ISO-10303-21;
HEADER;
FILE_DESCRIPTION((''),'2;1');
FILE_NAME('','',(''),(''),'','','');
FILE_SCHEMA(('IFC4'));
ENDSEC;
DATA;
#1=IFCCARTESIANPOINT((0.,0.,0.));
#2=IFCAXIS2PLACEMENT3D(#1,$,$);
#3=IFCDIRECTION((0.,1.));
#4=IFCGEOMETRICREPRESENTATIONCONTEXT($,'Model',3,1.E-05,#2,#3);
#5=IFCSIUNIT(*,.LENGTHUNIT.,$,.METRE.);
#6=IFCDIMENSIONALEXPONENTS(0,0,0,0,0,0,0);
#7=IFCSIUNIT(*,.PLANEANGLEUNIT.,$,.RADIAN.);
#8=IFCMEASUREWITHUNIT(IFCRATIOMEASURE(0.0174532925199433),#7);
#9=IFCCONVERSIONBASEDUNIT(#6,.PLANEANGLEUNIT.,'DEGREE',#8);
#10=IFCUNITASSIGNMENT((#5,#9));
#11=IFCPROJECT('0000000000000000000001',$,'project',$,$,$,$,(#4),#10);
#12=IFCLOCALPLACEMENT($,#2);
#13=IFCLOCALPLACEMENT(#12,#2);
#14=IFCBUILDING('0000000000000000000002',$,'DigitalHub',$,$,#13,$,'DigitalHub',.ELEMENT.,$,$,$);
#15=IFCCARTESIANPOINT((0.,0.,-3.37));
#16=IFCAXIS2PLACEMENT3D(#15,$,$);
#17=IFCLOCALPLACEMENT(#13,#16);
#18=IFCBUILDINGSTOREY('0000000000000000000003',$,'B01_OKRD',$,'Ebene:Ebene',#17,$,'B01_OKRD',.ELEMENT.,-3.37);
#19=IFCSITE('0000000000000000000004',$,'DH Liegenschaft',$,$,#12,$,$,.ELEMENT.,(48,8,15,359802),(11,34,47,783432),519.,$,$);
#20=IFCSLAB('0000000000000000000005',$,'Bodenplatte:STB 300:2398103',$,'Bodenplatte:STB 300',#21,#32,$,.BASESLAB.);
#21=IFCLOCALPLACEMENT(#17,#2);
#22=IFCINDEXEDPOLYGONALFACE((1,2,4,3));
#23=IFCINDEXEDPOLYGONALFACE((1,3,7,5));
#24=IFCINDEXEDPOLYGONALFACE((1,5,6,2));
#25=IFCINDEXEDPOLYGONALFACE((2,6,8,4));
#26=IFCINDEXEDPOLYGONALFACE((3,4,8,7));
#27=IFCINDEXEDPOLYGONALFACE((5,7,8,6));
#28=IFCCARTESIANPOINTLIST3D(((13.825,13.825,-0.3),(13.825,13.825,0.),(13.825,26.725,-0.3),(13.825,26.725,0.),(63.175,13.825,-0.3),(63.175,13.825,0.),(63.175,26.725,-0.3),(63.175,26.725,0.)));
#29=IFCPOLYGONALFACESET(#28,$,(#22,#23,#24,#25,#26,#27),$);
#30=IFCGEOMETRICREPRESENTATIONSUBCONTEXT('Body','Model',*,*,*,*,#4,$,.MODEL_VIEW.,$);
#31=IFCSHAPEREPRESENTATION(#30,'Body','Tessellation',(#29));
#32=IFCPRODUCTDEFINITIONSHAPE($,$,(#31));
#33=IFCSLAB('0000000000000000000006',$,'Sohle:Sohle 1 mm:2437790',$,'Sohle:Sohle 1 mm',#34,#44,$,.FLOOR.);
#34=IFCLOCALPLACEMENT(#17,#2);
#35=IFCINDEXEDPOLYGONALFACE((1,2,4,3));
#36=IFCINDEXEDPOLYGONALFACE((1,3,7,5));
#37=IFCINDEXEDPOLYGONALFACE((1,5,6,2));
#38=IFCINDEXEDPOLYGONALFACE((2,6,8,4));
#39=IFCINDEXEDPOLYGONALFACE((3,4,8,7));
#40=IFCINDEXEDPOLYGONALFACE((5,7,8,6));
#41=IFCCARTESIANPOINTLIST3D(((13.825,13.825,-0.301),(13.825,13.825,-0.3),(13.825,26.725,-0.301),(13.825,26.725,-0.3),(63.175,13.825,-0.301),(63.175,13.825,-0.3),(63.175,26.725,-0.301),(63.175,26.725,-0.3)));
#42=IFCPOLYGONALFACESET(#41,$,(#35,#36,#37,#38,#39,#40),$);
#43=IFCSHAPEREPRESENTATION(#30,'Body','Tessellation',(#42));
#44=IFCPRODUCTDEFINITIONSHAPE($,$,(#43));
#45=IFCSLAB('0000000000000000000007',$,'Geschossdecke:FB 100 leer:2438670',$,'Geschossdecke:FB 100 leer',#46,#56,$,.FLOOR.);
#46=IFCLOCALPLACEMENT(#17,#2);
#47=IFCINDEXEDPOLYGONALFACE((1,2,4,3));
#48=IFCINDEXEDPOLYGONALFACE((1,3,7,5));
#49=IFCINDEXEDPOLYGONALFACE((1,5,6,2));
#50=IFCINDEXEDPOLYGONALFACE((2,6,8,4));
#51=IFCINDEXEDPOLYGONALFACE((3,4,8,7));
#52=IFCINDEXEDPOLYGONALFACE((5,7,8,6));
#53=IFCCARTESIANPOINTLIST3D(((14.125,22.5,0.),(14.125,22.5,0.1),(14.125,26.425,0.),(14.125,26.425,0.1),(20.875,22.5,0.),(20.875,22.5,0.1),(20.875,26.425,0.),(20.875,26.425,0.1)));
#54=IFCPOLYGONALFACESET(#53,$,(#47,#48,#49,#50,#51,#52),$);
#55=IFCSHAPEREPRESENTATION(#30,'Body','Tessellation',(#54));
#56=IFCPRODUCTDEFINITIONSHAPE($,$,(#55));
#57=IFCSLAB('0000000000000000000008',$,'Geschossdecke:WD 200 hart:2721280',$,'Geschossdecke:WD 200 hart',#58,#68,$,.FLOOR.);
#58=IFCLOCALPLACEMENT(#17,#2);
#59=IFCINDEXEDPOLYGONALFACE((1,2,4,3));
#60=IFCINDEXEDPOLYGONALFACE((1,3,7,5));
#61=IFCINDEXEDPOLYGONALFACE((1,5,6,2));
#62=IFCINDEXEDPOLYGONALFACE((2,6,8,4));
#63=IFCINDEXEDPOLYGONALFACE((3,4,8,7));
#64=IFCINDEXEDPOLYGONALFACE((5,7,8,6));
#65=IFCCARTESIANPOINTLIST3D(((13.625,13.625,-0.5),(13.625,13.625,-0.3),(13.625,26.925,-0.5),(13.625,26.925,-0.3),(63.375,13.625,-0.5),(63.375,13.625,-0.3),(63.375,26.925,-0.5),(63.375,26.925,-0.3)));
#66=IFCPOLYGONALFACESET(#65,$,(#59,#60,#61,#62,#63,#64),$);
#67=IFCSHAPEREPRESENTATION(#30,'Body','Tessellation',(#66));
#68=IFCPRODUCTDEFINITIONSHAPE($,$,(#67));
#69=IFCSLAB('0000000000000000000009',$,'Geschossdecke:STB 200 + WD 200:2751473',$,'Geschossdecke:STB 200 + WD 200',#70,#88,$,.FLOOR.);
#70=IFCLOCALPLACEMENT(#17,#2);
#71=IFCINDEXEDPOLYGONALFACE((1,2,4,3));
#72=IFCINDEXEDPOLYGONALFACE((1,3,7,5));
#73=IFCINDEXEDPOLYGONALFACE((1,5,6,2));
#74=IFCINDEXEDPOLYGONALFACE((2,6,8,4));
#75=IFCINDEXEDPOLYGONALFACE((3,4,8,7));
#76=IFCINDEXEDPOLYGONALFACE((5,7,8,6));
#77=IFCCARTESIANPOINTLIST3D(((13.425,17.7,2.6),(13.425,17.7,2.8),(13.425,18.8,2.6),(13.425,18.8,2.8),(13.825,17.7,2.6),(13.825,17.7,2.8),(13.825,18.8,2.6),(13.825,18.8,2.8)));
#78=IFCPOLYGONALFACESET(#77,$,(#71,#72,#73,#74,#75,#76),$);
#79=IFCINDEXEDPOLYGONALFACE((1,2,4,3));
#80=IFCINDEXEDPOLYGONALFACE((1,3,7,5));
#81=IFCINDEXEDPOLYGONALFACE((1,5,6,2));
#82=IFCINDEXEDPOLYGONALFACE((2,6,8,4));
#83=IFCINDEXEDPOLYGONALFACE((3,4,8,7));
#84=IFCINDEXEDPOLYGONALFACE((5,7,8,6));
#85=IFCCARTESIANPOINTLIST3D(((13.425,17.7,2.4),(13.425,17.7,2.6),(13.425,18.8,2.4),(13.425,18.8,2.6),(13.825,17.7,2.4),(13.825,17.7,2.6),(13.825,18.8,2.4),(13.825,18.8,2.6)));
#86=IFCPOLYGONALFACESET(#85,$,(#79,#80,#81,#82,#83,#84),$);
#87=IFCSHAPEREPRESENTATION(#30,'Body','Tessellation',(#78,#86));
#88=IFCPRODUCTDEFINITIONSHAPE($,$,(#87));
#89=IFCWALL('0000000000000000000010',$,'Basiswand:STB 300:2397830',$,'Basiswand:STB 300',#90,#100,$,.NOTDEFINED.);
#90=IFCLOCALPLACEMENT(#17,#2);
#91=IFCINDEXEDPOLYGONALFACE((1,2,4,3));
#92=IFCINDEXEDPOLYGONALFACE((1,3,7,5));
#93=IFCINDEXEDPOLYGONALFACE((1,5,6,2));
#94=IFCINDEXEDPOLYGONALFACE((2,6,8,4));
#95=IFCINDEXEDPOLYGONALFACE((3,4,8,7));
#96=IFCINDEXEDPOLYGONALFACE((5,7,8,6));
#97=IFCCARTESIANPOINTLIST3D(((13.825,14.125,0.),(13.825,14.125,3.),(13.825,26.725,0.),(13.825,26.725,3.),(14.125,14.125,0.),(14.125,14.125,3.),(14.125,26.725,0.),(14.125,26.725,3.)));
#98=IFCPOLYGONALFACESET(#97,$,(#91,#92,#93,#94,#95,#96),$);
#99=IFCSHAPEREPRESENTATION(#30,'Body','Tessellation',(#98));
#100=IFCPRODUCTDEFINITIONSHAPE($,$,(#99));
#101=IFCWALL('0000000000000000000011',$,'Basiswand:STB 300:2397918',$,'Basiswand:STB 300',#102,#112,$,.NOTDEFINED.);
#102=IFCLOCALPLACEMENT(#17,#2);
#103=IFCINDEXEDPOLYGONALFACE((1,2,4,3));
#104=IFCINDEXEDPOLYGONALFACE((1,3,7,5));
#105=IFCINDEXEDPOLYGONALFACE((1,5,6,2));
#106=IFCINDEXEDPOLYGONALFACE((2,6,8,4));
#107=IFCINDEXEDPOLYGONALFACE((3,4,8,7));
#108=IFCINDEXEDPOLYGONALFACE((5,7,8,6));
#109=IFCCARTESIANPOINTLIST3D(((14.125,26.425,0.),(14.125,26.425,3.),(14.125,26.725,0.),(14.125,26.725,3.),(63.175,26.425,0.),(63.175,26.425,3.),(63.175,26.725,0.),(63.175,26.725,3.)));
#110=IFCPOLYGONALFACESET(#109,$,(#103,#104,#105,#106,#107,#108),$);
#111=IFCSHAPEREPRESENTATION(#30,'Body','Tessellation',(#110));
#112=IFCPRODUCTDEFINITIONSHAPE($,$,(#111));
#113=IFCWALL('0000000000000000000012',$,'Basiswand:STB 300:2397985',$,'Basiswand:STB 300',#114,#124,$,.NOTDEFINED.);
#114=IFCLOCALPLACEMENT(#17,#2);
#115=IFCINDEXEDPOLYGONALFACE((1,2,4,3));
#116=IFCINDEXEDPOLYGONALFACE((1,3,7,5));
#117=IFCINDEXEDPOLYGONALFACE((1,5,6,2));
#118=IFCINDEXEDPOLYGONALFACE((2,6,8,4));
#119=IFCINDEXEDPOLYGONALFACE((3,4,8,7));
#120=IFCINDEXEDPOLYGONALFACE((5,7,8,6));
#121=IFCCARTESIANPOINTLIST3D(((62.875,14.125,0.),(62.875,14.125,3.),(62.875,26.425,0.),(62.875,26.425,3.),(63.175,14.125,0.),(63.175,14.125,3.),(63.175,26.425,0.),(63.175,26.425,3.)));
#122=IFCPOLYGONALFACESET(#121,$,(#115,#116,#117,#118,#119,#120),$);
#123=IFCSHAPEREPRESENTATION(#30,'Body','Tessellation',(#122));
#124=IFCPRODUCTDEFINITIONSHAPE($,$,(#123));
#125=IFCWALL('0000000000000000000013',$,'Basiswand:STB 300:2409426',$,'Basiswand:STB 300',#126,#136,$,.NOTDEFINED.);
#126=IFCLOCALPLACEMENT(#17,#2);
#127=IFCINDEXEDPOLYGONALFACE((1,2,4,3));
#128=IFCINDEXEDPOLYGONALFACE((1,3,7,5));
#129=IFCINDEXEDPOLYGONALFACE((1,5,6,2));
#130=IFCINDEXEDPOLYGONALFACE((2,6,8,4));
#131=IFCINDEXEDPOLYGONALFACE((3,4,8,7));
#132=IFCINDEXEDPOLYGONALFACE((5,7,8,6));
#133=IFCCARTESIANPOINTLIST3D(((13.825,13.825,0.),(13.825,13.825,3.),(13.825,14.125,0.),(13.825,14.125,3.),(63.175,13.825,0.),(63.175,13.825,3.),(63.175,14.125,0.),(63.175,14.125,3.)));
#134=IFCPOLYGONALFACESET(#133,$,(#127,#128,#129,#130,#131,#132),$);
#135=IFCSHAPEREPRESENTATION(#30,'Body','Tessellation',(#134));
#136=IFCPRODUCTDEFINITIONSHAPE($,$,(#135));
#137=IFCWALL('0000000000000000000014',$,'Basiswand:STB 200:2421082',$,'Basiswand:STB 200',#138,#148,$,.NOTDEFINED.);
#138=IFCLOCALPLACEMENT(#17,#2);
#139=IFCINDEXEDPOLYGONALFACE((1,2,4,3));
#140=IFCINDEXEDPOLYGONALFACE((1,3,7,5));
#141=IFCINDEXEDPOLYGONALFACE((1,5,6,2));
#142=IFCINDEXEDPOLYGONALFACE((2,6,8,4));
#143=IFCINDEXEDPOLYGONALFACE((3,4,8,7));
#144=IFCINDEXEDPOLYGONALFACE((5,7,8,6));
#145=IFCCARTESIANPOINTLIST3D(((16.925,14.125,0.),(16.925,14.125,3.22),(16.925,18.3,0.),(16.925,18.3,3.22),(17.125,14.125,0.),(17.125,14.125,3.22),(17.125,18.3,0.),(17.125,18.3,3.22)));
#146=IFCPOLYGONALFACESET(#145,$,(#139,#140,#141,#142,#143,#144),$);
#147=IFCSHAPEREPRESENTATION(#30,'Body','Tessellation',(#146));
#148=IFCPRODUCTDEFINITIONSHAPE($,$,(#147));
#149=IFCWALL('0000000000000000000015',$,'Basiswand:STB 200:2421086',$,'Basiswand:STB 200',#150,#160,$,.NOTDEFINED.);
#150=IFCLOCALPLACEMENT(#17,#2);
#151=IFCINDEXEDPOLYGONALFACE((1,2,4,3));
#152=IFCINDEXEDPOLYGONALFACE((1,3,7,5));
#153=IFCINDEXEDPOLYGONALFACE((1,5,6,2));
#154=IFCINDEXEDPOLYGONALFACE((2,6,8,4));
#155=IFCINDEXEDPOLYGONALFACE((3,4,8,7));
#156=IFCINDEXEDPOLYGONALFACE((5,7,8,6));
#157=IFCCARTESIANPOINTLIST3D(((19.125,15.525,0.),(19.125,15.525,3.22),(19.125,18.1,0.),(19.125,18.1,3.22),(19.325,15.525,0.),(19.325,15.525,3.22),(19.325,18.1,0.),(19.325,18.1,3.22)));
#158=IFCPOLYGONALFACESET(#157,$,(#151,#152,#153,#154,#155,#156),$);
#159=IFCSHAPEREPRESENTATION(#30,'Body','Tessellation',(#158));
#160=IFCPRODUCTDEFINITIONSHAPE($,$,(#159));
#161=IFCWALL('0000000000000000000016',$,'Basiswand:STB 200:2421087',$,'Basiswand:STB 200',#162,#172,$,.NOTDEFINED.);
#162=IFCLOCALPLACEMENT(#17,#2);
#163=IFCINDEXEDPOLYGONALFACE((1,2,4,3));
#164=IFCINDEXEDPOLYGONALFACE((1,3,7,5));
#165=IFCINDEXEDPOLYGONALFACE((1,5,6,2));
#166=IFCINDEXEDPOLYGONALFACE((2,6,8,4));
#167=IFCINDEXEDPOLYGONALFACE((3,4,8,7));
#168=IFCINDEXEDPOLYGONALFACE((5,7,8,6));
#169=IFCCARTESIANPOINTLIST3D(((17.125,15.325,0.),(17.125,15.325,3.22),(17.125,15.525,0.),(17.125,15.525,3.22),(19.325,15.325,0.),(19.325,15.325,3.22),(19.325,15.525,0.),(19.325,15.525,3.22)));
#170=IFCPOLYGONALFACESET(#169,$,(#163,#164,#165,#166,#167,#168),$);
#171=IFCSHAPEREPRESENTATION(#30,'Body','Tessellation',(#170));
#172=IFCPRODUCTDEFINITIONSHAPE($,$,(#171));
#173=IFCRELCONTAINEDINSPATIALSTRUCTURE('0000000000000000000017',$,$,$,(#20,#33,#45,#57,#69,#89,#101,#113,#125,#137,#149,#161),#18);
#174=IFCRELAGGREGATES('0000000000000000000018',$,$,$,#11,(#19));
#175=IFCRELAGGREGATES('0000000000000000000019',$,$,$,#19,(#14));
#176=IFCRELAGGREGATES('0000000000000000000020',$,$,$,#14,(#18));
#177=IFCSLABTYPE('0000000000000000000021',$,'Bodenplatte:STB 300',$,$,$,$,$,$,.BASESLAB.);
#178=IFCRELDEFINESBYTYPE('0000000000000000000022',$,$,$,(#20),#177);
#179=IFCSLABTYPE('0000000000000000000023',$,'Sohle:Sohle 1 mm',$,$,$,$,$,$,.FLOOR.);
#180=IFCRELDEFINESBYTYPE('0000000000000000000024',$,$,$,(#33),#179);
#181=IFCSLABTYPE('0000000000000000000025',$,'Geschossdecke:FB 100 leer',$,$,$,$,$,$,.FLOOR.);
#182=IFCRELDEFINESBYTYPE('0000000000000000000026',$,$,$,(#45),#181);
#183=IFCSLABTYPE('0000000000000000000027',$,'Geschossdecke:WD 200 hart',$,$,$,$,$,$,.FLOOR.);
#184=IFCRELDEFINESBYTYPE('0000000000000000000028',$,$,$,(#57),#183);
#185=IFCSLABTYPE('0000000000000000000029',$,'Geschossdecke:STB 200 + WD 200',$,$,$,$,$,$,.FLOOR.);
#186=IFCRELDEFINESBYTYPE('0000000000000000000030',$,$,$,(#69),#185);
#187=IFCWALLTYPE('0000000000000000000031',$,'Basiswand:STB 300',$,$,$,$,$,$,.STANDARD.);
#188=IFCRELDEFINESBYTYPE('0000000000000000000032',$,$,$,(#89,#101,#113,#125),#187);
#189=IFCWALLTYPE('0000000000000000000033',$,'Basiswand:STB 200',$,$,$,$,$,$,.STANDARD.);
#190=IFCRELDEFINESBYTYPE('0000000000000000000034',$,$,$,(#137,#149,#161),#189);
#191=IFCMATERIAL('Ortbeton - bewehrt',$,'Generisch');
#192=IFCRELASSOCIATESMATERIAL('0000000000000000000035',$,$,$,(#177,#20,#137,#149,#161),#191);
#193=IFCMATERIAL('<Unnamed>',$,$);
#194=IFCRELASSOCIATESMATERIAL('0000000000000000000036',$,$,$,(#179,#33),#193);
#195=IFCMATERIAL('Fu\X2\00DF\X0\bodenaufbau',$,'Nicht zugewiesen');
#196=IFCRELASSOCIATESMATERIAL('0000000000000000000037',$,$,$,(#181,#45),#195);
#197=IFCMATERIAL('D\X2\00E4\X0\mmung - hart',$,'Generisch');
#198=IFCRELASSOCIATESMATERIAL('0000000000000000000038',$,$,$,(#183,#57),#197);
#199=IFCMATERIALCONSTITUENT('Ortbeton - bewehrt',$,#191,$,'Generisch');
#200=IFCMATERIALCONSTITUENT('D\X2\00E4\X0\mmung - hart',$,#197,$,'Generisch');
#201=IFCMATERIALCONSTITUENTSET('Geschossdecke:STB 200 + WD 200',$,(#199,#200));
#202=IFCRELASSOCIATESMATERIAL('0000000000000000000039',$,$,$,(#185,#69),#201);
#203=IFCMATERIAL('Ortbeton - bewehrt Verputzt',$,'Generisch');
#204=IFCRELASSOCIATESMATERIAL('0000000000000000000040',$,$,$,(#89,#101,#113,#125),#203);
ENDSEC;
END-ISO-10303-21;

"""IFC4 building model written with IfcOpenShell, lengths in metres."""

from ifc_helpers import new_model, entity, si_unit, converted_unit, direction, frame, origin, place, context, subcontext, project, spatial, indexed_curve, outline, extrude, material, constituent, constituent_set, type_object, element, save


model = new_model("IFC4")

# Units and contexts
model_context = context("Model", 3, precision=1e-05, world=origin(), true_north=direction((0.0, 1.0)))
body_context = subcontext(model_context, "Body", "Model", "MODEL_VIEW")
ifc_project = project(units=[si_unit("LENGTHUNIT", "METRE"), converted_unit("PLANEANGLEUNIT", "DEGREE", entity("IfcRatioMeasure", 0.0174532925199433), si_unit("PLANEANGLEUNIT", "RADIAN"), dimensions=[0, 0, 0, 0, 0, 0, 0])], contexts=[model_context])

# Site, building, storey
site_placement = place(None, frame((0.0, 0.0, 0.0)))
site = spatial("IfcSite", under=ifc_project, at=site_placement, Name="DH Liegenschaft", CompositionType="ELEMENT", RefLatitude=(48, 8, 15, 359802), RefLongitude=(11, 34, 47, 783432), RefElevation=519.0)
building_placement = place(site_placement, origin())
building = spatial("IfcBuilding", under=site, at=building_placement, Name="DigitalHub", LongName="DigitalHub", CompositionType="ELEMENT")
storey_placement = place(building_placement, frame((0.0, 0.0, -3.37)))
storey = spatial("IfcBuildingStorey", under=building, at=storey_placement, Name="B01_OKRD", ObjectType="Ebene:Ebene", LongName="B01_OKRD", CompositionType="ELEMENT", Elevation=-3.37)

# Slabs
ifc_material_1 = material(Name="Ortbeton - bewehrt", Category="Generisch")
slab_type_1 = type_object("IfcSlabType", Name="Bodenplatte:STB 300", PredefinedType="BASESLAB", material=ifc_material_1)
slab_1_placement = place(storey_placement, origin())
element("IfcSlab", 1, at=slab_1_placement, inside=storey, type_object=slab_type_1, material=ifc_material_1, Name="Bodenplatte:STB 300:2398103", ObjectType="Bodenplatte:STB 300", PredefinedType="BASESLAB", context=body_context, shape_type="SweptSolid", body=[
    extrude(outline(indexed_curve([(-6.45, -24.675), (6.45, -24.675), (6.45, 24.675), (-6.45, 24.675), (-6.45, -24.675)], self_intersect=False)), frame((38.5, 20.275, 0.0), z_axis=(0.0, 0.0, -1.0), x_axis=(0.0, 1.0, 0.0)), (0.0, 0.0, 1.0), 0.3),
])
ifc_material_2 = material(Name="<Unnamed>")
slab_type_2 = type_object("IfcSlabType", Name="Sohle:Sohle 1 mm", PredefinedType="FLOOR", material=ifc_material_2)
slab_2_placement = place(storey_placement, origin())
element("IfcSlab", 2, at=slab_2_placement, inside=storey, type_object=slab_type_2, material=ifc_material_2, Name="Sohle:Sohle 1 mm:2437790", ObjectType="Sohle:Sohle 1 mm", PredefinedType="FLOOR", context=body_context, shape_type="SweptSolid", body=[
    extrude(outline(indexed_curve([(-6.45, -24.675), (6.45, -24.675), (6.45, 24.675), (-6.45, 24.675), (-6.45, -24.675)], self_intersect=False)), frame((38.5, 20.275, -0.301), z_axis=(0.0, 0.0, 1.0), x_axis=(0.0, 1.0, 0.0)), (0.0, 0.0, 1.0), 0.001),
])
ifc_material_3 = material(Name="Fußbodenaufbau", Category="Nicht zugewiesen")
slab_type_3 = type_object("IfcSlabType", Name="Geschossdecke:FB 100 leer", PredefinedType="FLOOR", material=ifc_material_3)
slab_3_placement = place(storey_placement, origin())
element("IfcSlab", 3, at=slab_3_placement, inside=storey, type_object=slab_type_3, material=ifc_material_3, Name="Geschossdecke:FB 100 leer:2438670", ObjectType="Geschossdecke:FB 100 leer", PredefinedType="FLOOR", context=body_context, shape_type="SweptSolid", body=[
    extrude(outline(indexed_curve([(-1.9625, -3.375), (1.9625, -3.375), (1.9625, 3.375), (-1.9625, 3.375), (-1.9625, -3.375)], self_intersect=False)), frame((17.5, 24.4625, 0.1), z_axis=(0.0, 0.0, -1.0), x_axis=(0.0, 1.0, 0.0)), (0.0, 0.0, 1.0), 0.1),
])
ifc_material_4 = material(Name="Dämmung - hart", Category="Generisch")
slab_type_4 = type_object("IfcSlabType", Name="Geschossdecke:WD 200 hart", PredefinedType="FLOOR", material=ifc_material_4)
slab_4_placement = place(storey_placement, origin())
element("IfcSlab", 4, at=slab_4_placement, inside=storey, type_object=slab_type_4, material=ifc_material_4, Name="Geschossdecke:WD 200 hart:2721280", ObjectType="Geschossdecke:WD 200 hart", PredefinedType="FLOOR", context=body_context, shape_type="SweptSolid", body=[
    extrude(outline(indexed_curve([(-6.65, -24.875), (6.65, -24.875), (6.65, 24.875), (-6.65, 24.875), (-6.65, -24.875)], self_intersect=False)), frame((38.5, 20.275, -0.3), z_axis=(0.0, 0.0, -1.0), x_axis=(0.0, 1.0, 0.0)), (0.0, 0.0, 1.0), 0.2),
])
ifc_constituent_1 = constituent(ifc_material_1, Name="Ortbeton - bewehrt", Category="Generisch")
ifc_constituent_2 = constituent(ifc_material_4, Name="Dämmung - hart", Category="Generisch")
ifc_constituent_set = constituent_set(constituents=[ifc_constituent_1, ifc_constituent_2], Name="Geschossdecke:STB 200 + WD 200")
slab_type_5 = type_object("IfcSlabType", Name="Geschossdecke:STB 200 + WD 200", PredefinedType="FLOOR", material=ifc_constituent_set)
slab_5_placement = place(storey_placement, origin())
element("IfcSlab", 5, at=slab_5_placement, inside=storey, type_object=slab_type_5, material=ifc_constituent_set, Name="Geschossdecke:STB 200 + WD 200:2751473", ObjectType="Geschossdecke:STB 200 + WD 200", PredefinedType="FLOOR", context=body_context, shape_type="SweptSolid", body=[
    extrude(outline(indexed_curve([(-0.2, -0.55), (0.2, -0.55), (0.2, 0.55), (-0.2, 0.55), (-0.2, -0.55)], self_intersect=False)), frame((13.625, 18.25, 2.6), z_axis=(0.0, 0.0, 1.0), x_axis=(-1.0, 0.0, 0.0)), (0.0, 0.0, 1.0), 0.2),
    extrude(outline(indexed_curve([(-0.2, -0.55), (0.2, -0.55), (0.2, 0.55), (-0.2, 0.55), (-0.2, -0.55)], self_intersect=False)), frame((13.625, 18.25, 2.4), z_axis=(0.0, 0.0, 1.0), x_axis=(-1.0, 0.0, 0.0)), (0.0, 0.0, 1.0), 0.2),
])

# Walls
ifc_material_5 = material(Name="Ortbeton - bewehrt Verputzt", Category="Generisch")
wall_type_1 = type_object("IfcWallType", Name="Basiswand:STB 300", PredefinedType="STANDARD")
wall_1_placement = place(storey_placement, frame((13.975, 14.125, 0.0), z_axis=(0.0, 0.0, 1.0), x_axis=(0.0, 1.0, 0.0)))
element("IfcWall", 6, at=wall_1_placement, inside=storey, type_object=wall_type_1, material=ifc_material_5, Name="Basiswand:STB 300:2397830", ObjectType="Basiswand:STB 300", PredefinedType="NOTDEFINED", context=body_context, shape_type="SweptSolid", body=[
    extrude(outline(indexed_curve([(12.6, 0.15), (0.0, 0.15), (0.0, -0.15), (12.6, -0.15), (12.6, 0.15)], self_intersect=False)), origin(), (0.0, 0.0, 1.0), 3.0),
])
wall_2_placement = place(storey_placement, frame((14.125, 26.575, 0.0)))
element("IfcWall", 7, at=wall_2_placement, inside=storey, type_object=wall_type_1, material=ifc_material_5, Name="Basiswand:STB 300:2397918", ObjectType="Basiswand:STB 300", PredefinedType="NOTDEFINED", context=body_context, shape_type="SweptSolid", body=[
    extrude(outline(indexed_curve([(49.05, 0.15), (0.0, 0.15), (0.0, -0.15), (49.05, -0.15), (49.05, 0.15)], self_intersect=False)), origin(), (0.0, 0.0, 1.0), 3.0),
])
wall_3_placement = place(storey_placement, frame((63.025, 26.425, 0.0), z_axis=(0.0, 0.0, 1.0), x_axis=(0.0, -1.0, 0.0)))
element("IfcWall", 8, at=wall_3_placement, inside=storey, type_object=wall_type_1, material=ifc_material_5, Name="Basiswand:STB 300:2397985", ObjectType="Basiswand:STB 300", PredefinedType="NOTDEFINED", context=body_context, shape_type="SweptSolid", body=[
    extrude(outline(indexed_curve([(12.3, 0.15), (0.0, 0.15), (0.0, -0.15), (12.3, -0.15), (12.3, 0.15)], self_intersect=False)), origin(), (0.0, 0.0, 1.0), 3.0),
])
wall_4_placement = place(storey_placement, frame((63.175, 13.975, 0.0), z_axis=(0.0, 0.0, 1.0), x_axis=(-1.0, 0.0, 0.0)))
element("IfcWall", 9, at=wall_4_placement, inside=storey, type_object=wall_type_1, material=ifc_material_5, Name="Basiswand:STB 300:2409426", ObjectType="Basiswand:STB 300", PredefinedType="NOTDEFINED", context=body_context, shape_type="SweptSolid", body=[
    extrude(outline(indexed_curve([(49.35, 0.15), (0.0, 0.15), (0.0, -0.15), (49.35, -0.15), (49.35, 0.15)], self_intersect=False)), origin(), (0.0, 0.0, 1.0), 3.0),
])
wall_type_2 = type_object("IfcWallType", Name="Basiswand:STB 200", PredefinedType="STANDARD")
wall_5_placement = place(storey_placement, frame((17.025, 14.125, 0.0), z_axis=(0.0, 0.0, 1.0), x_axis=(0.0, 1.0, 0.0)))
element("IfcWall", 10, at=wall_5_placement, inside=storey, type_object=wall_type_2, material=ifc_material_1, Name="Basiswand:STB 200:2421082", ObjectType="Basiswand:STB 200", PredefinedType="NOTDEFINED", context=body_context, shape_type="SweptSolid", body=[
    extrude(outline(indexed_curve([(4.175, 0.1), (0.0, 0.1), (0.0, -0.1), (4.175, -0.1), (4.175, 0.1)], self_intersect=False)), origin(), (0.0, 0.0, 1.0), 3.22),
])
wall_6_placement = place(storey_placement, frame((19.225, 15.525, 0.0), z_axis=(0.0, 0.0, 1.0), x_axis=(0.0, 1.0, 0.0)))
element("IfcWall", 11, at=wall_6_placement, inside=storey, type_object=wall_type_2, material=ifc_material_1, Name="Basiswand:STB 200:2421086", ObjectType="Basiswand:STB 200", PredefinedType="NOTDEFINED", context=body_context, shape_type="SweptSolid", body=[
    extrude(outline(indexed_curve([(2.575, 0.1), (0.0, 0.1), (0.0, -0.1), (2.575, -0.1), (2.575, 0.1)], self_intersect=False)), origin(), (0.0, 0.0, 1.0), 3.22),
])
wall_7_placement = place(storey_placement, frame((17.125, 15.425, 0.0)))
element("IfcWall", 12, at=wall_7_placement, inside=storey, type_object=wall_type_2, material=ifc_material_1, Name="Basiswand:STB 200:2421087", ObjectType="Basiswand:STB 200", PredefinedType="NOTDEFINED", context=body_context, shape_type="SweptSolid", body=[
    extrude(outline(indexed_curve([(2.2, 0.1), (0.0, 0.1), (0.0, -0.1), (2.2, -0.1), (2.2, 0.1)], self_intersect=False)), origin(), (0.0, 0.0, 1.0), 3.22),
])

save(model, "model.ifc")
